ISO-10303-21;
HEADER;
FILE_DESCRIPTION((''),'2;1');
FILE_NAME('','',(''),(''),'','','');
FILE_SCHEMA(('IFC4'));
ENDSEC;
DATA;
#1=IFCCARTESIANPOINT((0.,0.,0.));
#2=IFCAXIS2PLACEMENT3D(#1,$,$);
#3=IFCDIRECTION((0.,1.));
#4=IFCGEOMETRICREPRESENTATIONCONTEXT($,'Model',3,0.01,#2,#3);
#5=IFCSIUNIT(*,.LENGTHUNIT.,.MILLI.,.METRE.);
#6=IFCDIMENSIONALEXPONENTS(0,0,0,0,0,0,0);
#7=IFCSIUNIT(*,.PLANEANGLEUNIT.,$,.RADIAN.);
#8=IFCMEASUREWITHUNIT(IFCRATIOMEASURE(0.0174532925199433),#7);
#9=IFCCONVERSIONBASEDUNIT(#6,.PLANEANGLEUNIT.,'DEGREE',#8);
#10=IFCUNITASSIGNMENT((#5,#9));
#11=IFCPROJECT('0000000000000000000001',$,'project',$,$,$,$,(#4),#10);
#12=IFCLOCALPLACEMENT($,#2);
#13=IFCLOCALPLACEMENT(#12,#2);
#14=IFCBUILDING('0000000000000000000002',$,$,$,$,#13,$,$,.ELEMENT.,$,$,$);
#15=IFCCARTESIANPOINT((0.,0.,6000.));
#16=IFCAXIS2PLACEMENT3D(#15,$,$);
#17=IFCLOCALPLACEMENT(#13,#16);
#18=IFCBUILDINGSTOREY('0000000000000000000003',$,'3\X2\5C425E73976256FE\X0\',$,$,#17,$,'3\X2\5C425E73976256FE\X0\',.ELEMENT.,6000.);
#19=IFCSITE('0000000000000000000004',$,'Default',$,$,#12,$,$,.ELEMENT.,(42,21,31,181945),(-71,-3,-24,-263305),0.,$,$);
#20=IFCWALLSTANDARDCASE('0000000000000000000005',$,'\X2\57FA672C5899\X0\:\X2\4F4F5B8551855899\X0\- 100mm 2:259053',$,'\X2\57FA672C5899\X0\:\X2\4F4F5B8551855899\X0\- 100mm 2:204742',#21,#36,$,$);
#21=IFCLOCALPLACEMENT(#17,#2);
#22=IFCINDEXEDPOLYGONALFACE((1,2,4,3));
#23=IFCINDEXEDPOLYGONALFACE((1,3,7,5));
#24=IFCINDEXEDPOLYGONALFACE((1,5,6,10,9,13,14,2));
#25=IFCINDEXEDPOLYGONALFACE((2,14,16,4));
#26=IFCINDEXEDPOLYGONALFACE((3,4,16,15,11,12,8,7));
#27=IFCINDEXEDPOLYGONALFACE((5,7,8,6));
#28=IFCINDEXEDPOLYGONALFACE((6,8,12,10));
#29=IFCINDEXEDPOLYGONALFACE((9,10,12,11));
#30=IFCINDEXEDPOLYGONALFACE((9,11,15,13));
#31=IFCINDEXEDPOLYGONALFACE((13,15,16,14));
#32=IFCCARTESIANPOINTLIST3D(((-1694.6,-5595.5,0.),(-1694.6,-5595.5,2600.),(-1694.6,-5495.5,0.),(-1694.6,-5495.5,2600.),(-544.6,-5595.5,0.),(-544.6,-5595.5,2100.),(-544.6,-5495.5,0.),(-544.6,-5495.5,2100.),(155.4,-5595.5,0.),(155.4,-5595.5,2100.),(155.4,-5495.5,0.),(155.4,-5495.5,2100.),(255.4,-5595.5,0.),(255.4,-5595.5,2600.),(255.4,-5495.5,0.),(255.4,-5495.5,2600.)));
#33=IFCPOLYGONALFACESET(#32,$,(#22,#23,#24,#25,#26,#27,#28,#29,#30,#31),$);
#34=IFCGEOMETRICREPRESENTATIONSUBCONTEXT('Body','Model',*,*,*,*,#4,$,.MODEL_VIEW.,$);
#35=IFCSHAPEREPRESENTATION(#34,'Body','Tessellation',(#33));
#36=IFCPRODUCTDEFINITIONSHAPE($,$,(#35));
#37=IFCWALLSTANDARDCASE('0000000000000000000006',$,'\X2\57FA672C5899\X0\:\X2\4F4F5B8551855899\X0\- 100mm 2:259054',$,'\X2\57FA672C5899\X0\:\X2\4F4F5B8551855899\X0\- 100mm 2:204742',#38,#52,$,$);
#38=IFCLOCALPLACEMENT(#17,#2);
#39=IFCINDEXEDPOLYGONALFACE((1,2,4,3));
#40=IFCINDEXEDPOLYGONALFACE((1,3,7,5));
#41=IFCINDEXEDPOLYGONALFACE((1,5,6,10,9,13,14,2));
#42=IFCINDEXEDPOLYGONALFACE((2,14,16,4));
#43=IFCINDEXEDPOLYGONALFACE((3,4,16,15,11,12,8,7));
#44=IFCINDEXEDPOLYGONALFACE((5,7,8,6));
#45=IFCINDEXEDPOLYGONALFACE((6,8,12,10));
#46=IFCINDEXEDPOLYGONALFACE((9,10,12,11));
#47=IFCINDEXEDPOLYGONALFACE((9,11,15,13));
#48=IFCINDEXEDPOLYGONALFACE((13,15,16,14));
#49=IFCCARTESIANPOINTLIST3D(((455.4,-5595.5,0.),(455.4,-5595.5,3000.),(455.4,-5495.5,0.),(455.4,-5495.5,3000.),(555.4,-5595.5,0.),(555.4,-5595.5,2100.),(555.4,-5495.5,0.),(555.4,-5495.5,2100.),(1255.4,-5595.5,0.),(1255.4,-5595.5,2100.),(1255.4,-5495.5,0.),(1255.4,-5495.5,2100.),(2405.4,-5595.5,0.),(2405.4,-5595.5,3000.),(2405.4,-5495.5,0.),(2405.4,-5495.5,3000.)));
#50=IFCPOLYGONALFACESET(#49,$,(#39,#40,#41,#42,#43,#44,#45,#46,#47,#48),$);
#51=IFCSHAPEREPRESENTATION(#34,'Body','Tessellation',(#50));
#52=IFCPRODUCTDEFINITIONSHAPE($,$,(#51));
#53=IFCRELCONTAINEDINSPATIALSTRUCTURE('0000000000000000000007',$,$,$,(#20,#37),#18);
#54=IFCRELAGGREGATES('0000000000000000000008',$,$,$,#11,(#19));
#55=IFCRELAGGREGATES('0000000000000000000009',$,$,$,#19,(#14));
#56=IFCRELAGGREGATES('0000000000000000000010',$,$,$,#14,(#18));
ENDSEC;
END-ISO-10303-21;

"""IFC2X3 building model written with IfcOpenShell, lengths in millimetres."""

from ifc_helpers import new_model, entity, si_unit, converted_unit, direction, frame, frame_2d, origin, place, context, subcontext, project, spatial, polyline, rectangle, extrude, clip, bounded_halfspace, element, save


model = new_model("IFC2X3")

# Units and contexts
model_context = context("Model", 3, precision=0.01, world=origin(), true_north=direction((0.0, 1.0)))
body_context = subcontext(model_context, "Body", "Model", "MODEL_VIEW")
ifc_project = project(units=[si_unit("LENGTHUNIT", "METRE", prefix="MILLI"), converted_unit("PLANEANGLEUNIT", "DEGREE", entity("IfcRatioMeasure", 0.0174532925199433), si_unit("PLANEANGLEUNIT", "RADIAN"), dimensions=[0, 0, 0, 0, 0, 0, 0])], contexts=[model_context])

# Site, building, storey
site_placement = place(None, origin())
site = spatial("IfcSite", under=ifc_project, at=site_placement, Name="Default", CompositionType="ELEMENT", RefLatitude=(42, 21, 31, 181945), RefLongitude=(-71, -3, -24, -263305), RefElevation=0.0)
building_placement = place(site_placement, origin())
building = spatial("IfcBuilding", under=site, at=building_placement, CompositionType="ELEMENT")
storey_placement = place(building_placement, frame((0.0, 0.0, 6000.0)))
storey = spatial("IfcBuildingStorey", under=building, at=storey_placement, Name="3层平面图", LongName="3层平面图", CompositionType="ELEMENT", Elevation=6000.0)

# Walls, openings
wall_1_placement = place(storey_placement, frame((-1694.6, -5545.5, 0.0)))
wall_1 = element("IfcWallStandardCase", 1, at=wall_1_placement, inside=storey, Name="基本墙:住宅内墙- 100mm 2:259053", ObjectType="基本墙:住宅内墙- 100mm 2:204742", context=body_context, shape_type="Clipping", body=[
    clip(extrude(rectangle(XDim=1950.0, YDim=100.0, at=frame_2d((975.0, 0.0), x_axis=(-1.0, 0.0))), origin(), (0.0, 0.0, 1.0), 2600.0), bounded_halfspace(frame((0.0, -50.0, 2600.0), z_axis=(0.0, 0.0, -1.0), x_axis=(-1.0, 0.0, 0.0)), True, frame((0.0, -50.0, 2600.0), z_axis=(0.0, 0.0, -1.0), x_axis=(-1.0, 0.0, 0.0)), polyline([(0.0, 0.0), (0.0, 100.0), (-1950.0, 100.0), (-1950.0, 0.0), (0.0, 0.0)]))),
])
opening_1_placement = place(wall_1_placement, frame((1150.0, -50.0, 0.0)))
element("IfcOpeningElement", 2, at=opening_1_placement, cuts=wall_1, ObjectType="Opening", context=body_context, shape_type="SweptSolid", body=[
    extrude(rectangle(XDim=2100.0, YDim=700.0, at=frame_2d((1050.0, 350.0), x_axis=(1.0, 0.0))), frame((0.0, 0.0, 0.0), z_axis=(0.0, 1.0, 0.0), x_axis=(0.0, 0.0, 1.0)), (0.0, 0.0, 1.0), 100.0),
])
wall_2_placement = place(storey_placement, frame((2405.4, -5545.5, 0.0), z_axis=(0.0, 0.0, 1.0), x_axis=(-1.0, 0.0, 0.0)))
wall_2 = element("IfcWallStandardCase", 3, at=wall_2_placement, inside=storey, Name="基本墙:住宅内墙- 100mm 2:259054", ObjectType="基本墙:住宅内墙- 100mm 2:204742", context=body_context, shape_type="SweptSolid", body=[
    extrude(rectangle(XDim=1950.0, YDim=100.0, at=frame_2d((975.0, 0.0), x_axis=(-1.0, 0.0))), origin(), (0.0, 0.0, 1.0), 3000.0),
])
opening_2_placement = place(wall_2_placement, frame((1850.0, 50.0, 0.0)))
element("IfcOpeningElement", 4, at=opening_2_placement, cuts=wall_2, ObjectType="Opening", context=body_context, shape_type="SweptSolid", body=[
    extrude(rectangle(XDim=2100.0, YDim=700.0, at=frame_2d((1050.0, 350.0), x_axis=(1.0, 0.0))), frame((0.0, 0.0, 0.0), z_axis=(0.0, -1.0, 0.0), x_axis=(0.0, 0.0, 1.0)), (0.0, 0.0, 1.0), 100.0),
])

save(model, "model.ifc")
